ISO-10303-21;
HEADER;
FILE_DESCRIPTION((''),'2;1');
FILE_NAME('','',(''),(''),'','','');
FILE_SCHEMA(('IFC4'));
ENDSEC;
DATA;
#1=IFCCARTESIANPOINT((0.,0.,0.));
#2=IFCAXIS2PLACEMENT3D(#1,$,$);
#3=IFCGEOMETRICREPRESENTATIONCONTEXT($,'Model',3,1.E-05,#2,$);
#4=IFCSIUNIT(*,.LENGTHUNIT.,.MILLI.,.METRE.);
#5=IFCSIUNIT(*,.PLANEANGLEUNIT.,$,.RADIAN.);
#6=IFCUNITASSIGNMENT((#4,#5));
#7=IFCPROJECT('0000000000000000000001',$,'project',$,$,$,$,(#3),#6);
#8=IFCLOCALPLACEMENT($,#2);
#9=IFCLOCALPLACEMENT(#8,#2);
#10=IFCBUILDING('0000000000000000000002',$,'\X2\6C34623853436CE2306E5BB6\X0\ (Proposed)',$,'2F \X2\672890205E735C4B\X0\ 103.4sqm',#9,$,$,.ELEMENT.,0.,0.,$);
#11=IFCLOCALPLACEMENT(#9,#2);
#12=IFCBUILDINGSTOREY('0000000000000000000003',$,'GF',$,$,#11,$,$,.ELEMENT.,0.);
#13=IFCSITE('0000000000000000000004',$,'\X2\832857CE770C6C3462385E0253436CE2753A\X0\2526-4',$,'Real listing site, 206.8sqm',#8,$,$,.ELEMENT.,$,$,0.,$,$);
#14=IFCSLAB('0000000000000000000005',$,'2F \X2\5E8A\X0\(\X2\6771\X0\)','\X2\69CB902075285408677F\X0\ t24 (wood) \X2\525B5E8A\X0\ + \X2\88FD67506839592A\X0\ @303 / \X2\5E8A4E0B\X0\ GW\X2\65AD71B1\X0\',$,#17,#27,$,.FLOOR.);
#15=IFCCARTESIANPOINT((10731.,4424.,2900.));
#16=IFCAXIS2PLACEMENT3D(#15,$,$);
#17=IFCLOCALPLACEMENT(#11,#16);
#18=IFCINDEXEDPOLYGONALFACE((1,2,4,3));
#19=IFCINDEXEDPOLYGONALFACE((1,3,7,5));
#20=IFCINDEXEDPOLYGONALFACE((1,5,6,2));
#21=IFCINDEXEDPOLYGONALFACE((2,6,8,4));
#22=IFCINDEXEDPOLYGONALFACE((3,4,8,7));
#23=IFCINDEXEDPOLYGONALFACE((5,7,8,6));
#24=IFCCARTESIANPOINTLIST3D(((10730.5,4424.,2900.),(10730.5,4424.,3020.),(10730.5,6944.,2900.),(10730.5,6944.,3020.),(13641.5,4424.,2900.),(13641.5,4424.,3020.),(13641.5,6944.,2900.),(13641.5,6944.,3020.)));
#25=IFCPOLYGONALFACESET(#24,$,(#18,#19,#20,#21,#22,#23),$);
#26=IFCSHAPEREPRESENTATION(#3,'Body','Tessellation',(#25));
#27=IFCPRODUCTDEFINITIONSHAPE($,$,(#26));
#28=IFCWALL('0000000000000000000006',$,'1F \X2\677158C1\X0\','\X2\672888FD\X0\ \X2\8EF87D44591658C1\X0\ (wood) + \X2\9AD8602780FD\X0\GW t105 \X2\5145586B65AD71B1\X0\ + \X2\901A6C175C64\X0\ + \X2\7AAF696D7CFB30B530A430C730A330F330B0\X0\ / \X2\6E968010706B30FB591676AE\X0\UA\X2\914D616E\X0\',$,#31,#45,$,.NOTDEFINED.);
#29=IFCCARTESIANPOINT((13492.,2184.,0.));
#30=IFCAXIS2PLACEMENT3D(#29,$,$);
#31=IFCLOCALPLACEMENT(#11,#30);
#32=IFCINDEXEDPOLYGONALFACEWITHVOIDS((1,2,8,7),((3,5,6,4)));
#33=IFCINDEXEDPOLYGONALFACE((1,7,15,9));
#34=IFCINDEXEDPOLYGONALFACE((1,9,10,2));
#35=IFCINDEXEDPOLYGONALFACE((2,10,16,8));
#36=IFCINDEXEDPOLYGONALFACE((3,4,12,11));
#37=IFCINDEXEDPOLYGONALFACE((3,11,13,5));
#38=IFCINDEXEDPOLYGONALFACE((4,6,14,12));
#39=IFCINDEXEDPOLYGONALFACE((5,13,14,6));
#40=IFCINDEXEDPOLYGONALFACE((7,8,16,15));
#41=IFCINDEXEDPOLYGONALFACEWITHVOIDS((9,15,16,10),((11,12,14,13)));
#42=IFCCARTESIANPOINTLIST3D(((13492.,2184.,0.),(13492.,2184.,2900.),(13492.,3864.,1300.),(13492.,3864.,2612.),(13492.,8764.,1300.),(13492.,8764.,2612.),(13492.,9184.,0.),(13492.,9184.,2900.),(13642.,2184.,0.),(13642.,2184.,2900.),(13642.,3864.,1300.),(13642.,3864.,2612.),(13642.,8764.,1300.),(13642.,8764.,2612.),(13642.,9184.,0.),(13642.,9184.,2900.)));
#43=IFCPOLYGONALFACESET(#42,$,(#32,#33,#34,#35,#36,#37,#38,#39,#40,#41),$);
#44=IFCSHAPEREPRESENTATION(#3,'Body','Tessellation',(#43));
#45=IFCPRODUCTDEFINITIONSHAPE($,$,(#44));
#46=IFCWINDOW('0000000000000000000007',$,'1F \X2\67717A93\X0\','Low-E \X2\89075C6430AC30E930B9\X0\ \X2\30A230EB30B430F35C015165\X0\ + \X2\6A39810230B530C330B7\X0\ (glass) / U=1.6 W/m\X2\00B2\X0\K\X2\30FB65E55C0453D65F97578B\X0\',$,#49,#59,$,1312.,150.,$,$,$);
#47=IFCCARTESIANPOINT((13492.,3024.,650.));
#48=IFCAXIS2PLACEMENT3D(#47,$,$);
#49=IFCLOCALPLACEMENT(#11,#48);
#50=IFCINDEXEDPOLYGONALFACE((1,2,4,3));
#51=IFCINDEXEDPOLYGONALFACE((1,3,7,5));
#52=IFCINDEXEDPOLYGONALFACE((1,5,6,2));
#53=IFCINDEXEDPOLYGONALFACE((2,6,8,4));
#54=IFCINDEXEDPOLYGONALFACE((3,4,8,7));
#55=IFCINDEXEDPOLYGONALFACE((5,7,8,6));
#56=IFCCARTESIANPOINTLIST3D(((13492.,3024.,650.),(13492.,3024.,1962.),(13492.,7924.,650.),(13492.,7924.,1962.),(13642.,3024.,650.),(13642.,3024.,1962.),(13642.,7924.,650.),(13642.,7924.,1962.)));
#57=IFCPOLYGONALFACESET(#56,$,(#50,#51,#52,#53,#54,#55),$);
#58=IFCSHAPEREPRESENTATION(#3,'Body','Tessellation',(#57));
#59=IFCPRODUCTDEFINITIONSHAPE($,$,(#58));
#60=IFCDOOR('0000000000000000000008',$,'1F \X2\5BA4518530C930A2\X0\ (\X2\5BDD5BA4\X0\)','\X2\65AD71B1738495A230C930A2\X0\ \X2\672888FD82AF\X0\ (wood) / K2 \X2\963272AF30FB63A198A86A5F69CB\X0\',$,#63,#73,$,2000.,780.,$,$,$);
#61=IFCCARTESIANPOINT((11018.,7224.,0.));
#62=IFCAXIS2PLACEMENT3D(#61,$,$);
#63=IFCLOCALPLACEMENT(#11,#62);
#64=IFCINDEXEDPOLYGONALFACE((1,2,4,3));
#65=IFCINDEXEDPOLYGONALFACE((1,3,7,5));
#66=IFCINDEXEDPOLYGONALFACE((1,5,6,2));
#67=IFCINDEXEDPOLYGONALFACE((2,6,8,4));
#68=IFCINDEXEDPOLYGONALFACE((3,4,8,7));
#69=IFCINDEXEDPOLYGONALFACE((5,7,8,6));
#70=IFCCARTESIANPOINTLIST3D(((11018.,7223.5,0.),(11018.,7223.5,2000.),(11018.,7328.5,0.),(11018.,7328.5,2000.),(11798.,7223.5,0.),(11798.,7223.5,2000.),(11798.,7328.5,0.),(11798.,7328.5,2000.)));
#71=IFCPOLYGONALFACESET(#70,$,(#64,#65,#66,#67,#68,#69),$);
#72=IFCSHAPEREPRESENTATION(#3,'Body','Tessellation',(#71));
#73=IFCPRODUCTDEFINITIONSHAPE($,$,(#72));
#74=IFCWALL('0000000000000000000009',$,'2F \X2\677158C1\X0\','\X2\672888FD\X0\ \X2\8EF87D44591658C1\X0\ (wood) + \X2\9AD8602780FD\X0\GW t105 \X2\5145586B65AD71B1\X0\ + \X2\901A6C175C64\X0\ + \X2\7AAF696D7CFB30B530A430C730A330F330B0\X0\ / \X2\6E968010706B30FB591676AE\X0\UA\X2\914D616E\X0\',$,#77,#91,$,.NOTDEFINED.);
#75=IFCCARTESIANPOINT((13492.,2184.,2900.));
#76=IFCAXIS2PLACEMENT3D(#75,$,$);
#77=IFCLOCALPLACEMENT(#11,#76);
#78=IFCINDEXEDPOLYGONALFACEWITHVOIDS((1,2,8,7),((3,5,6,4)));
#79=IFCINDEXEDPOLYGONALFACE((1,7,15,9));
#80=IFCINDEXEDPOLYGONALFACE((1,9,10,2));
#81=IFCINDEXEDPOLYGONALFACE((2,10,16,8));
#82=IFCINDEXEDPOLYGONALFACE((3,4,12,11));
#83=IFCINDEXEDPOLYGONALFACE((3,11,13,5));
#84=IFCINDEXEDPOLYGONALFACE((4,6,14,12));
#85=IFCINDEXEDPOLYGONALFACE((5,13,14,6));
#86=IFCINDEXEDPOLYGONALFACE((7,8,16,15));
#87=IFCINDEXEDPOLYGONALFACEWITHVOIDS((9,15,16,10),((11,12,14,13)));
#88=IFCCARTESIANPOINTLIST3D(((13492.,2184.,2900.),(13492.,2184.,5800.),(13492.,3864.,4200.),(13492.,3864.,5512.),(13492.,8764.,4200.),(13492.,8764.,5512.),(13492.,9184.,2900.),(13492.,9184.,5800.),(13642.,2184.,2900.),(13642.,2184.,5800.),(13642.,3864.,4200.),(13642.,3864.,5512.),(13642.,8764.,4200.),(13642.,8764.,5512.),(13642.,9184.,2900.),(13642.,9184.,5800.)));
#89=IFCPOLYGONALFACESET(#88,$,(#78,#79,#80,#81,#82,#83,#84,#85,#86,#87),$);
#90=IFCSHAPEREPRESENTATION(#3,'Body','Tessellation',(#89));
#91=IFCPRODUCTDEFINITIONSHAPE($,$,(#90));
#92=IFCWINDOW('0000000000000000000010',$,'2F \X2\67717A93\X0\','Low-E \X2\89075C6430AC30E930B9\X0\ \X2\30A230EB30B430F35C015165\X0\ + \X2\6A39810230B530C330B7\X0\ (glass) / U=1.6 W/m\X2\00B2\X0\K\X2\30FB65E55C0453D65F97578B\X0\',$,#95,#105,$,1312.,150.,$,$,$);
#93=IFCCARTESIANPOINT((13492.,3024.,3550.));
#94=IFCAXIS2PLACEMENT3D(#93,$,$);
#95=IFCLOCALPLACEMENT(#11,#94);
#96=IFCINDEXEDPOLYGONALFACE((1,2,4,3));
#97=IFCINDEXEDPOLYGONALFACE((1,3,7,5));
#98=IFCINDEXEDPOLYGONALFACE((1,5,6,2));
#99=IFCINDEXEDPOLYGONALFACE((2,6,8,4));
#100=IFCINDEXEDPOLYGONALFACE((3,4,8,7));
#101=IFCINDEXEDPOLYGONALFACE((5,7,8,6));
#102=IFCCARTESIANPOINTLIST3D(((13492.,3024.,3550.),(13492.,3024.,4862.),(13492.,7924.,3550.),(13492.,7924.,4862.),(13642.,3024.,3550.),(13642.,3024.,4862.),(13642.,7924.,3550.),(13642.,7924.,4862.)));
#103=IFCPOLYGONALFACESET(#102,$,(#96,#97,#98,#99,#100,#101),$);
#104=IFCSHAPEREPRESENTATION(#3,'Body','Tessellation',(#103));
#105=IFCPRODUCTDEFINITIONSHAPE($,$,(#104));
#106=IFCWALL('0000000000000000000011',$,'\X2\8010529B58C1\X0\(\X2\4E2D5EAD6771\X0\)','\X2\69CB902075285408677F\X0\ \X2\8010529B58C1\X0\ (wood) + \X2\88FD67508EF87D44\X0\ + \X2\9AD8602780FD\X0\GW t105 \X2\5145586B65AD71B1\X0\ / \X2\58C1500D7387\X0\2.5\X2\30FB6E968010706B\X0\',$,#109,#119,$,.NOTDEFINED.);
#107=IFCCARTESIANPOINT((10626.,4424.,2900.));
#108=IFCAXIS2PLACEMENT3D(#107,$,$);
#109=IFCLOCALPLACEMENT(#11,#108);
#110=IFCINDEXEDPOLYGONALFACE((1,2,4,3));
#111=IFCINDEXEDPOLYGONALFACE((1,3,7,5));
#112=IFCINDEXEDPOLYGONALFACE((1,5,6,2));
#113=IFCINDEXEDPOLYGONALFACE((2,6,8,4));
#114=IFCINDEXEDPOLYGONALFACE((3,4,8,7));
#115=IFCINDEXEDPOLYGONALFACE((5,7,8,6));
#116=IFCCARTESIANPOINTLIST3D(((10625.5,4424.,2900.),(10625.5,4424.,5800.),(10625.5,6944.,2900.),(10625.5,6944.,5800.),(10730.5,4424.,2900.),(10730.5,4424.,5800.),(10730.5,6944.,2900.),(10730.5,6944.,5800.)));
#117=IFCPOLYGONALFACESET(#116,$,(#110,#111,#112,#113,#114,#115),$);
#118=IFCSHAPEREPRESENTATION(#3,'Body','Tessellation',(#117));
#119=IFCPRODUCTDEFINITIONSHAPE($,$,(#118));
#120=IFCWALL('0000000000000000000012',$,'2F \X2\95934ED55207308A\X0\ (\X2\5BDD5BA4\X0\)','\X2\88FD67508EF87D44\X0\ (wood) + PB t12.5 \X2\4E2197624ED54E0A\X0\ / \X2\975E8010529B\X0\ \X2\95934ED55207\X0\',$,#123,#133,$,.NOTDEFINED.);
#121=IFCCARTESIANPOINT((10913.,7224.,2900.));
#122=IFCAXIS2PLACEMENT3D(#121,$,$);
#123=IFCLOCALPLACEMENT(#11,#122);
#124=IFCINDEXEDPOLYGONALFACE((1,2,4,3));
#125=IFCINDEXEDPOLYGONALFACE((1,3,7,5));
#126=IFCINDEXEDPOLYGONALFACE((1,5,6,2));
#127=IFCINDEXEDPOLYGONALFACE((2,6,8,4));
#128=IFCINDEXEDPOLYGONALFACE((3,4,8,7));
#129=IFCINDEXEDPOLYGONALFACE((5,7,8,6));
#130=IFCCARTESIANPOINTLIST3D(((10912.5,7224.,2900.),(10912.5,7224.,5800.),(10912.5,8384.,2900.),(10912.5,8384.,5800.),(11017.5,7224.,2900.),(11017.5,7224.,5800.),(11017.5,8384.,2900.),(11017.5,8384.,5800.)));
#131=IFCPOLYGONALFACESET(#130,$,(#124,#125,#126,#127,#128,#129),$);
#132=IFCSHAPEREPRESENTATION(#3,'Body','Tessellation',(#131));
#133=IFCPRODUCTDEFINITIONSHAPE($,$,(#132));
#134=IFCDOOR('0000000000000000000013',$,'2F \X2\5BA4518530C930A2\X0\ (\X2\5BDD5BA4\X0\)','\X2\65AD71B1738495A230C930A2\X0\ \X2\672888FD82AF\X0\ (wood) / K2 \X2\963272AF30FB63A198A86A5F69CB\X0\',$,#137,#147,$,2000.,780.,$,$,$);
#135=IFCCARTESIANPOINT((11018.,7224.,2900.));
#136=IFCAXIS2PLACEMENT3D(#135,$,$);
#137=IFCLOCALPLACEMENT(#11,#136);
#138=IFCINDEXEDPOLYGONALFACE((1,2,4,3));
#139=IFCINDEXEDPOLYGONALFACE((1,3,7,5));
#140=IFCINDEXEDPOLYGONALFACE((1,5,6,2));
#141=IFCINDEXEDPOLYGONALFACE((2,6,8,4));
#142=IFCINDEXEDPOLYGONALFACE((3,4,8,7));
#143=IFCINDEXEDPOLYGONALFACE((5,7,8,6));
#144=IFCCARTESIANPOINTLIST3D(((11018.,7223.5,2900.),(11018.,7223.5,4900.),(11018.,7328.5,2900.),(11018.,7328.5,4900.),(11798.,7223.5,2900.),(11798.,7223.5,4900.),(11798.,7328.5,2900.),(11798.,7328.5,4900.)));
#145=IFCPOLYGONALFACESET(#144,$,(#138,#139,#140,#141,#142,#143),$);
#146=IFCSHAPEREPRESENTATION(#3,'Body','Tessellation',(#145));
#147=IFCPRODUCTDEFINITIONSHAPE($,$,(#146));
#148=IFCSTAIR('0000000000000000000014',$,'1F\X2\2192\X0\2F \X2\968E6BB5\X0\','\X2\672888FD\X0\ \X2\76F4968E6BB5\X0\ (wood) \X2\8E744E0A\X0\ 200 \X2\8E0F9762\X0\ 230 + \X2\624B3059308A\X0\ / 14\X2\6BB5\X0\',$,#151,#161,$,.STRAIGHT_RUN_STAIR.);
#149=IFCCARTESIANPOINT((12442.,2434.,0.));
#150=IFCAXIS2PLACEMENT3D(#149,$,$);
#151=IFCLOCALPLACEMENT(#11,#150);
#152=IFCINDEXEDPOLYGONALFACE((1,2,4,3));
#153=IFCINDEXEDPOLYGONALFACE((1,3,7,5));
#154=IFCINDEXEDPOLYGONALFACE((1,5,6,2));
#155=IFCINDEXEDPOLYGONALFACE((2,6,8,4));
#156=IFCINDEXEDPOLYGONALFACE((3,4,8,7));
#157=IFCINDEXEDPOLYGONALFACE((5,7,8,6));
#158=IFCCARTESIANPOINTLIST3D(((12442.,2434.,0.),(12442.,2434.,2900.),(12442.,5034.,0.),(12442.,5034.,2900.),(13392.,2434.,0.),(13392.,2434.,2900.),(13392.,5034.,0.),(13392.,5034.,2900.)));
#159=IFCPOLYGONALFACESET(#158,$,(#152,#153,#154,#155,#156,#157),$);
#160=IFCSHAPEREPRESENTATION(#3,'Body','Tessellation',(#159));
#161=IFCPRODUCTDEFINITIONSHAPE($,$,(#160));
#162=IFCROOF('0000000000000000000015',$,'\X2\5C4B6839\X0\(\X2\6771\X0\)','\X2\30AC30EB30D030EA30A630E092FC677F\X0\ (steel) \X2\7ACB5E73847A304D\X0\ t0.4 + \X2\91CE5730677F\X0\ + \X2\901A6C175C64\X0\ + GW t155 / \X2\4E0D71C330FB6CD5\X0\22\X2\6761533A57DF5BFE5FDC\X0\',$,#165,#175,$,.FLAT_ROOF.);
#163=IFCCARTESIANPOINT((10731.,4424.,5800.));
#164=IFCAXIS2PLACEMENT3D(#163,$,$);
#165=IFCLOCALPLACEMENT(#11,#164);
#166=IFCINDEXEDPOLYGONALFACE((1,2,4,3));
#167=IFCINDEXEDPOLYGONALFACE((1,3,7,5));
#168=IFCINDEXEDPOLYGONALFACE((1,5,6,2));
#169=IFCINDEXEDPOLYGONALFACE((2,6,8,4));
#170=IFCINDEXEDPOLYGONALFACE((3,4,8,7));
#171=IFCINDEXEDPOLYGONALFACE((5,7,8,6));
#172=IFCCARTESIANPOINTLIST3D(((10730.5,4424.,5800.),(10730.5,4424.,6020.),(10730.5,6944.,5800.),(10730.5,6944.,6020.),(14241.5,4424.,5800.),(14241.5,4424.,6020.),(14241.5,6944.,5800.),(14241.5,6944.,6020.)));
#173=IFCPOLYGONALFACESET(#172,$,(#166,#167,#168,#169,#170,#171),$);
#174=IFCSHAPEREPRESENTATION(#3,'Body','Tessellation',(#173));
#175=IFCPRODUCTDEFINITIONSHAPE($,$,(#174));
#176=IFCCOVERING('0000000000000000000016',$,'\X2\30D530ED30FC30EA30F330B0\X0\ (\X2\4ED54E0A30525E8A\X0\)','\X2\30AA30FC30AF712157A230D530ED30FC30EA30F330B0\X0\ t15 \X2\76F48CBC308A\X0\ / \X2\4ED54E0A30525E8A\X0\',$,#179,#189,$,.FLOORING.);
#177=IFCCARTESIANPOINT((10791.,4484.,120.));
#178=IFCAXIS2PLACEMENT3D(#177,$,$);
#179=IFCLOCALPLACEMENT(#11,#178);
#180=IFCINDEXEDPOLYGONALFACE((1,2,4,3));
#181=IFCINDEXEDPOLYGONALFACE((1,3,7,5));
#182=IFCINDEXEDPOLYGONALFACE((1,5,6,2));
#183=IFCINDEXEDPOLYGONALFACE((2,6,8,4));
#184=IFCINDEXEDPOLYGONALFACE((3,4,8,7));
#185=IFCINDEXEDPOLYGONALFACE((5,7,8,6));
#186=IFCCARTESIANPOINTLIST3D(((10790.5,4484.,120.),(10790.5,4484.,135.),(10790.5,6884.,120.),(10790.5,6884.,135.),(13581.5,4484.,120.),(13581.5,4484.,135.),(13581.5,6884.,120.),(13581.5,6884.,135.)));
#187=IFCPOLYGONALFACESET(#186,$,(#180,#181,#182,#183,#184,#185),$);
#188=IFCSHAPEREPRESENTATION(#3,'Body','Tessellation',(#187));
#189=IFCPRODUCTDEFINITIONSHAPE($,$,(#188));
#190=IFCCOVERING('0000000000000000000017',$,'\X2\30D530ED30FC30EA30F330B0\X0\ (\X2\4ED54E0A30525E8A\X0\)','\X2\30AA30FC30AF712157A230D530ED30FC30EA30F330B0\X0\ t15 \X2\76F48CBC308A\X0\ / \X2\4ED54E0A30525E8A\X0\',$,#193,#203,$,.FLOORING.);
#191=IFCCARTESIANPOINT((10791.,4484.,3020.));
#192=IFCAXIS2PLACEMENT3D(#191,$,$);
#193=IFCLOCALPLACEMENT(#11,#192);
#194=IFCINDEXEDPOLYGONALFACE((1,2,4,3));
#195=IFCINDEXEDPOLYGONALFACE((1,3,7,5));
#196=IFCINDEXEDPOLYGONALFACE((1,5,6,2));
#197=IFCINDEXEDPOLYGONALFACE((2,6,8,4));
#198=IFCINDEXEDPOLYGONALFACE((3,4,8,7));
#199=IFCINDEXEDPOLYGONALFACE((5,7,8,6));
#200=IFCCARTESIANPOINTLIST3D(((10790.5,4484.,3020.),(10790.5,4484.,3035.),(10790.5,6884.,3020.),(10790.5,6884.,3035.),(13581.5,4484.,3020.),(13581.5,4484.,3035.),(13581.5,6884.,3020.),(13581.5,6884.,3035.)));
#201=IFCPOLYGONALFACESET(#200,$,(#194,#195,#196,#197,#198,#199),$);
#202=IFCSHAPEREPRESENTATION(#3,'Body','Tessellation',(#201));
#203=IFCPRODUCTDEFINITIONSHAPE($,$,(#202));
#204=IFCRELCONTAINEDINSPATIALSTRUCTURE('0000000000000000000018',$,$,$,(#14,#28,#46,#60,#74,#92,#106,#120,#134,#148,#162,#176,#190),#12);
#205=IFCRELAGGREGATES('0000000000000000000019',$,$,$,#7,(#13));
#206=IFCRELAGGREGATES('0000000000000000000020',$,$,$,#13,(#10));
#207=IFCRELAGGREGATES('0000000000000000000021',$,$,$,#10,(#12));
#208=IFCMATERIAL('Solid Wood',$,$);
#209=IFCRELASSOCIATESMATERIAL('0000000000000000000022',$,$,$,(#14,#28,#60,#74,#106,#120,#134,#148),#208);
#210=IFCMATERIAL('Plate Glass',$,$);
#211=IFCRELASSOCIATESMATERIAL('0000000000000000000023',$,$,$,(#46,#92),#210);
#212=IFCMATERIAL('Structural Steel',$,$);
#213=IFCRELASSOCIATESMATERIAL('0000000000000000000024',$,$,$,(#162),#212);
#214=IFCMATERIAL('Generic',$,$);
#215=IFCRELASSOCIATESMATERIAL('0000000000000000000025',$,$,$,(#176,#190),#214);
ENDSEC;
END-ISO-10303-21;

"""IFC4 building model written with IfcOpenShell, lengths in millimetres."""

from ifc_helpers import new_model, si_unit, frame, frame_2d, origin, place, context, project, spatial, rectangle, extrude, material, element, fill, save


model = new_model("IFC4")

# Units and contexts
model_context = context("Model", 3, precision=1e-05, world=origin())
ifc_project = project(units=[si_unit("LENGTHUNIT", "METRE", prefix="MILLI"), si_unit("PLANEANGLEUNIT", "RADIAN")], contexts=[model_context])

# Site, building, storey
site_placement = place(None, origin())
site = spatial("IfcSite", under=ifc_project, at=site_placement, Name="茨城県水戸市千波町2526-4", ObjectType="Real listing site, 206.8sqm", CompositionType="ELEMENT", RefElevation=0.0)
building_placement = place(site_placement, origin())
building = spatial("IfcBuilding", under=site, at=building_placement, Name="水戸千波の家 (Proposed)", ObjectType="2F 木造平屋 103.4sqm", CompositionType="ELEMENT", ElevationOfRefHeight=0.0, ElevationOfTerrain=0.0)
storey_placement = place(building_placement, origin())
storey = spatial("IfcBuildingStorey", under=building, at=storey_placement, Name="GF", CompositionType="ELEMENT", Elevation=0.0)

# Slab
ifc_material_1 = material(Name="Solid Wood")
slab_1_placement = place(storey_placement, frame((10731.0, 4424.0, 2900.0)))
element("IfcSlab", 1, at=slab_1_placement, inside=storey, material=ifc_material_1, Name="2F 床(東)", Description="構造用合板 t24 (wood) 剛床 + 製材根太 @303 / 床下 GW断熱", PredefinedType="FLOOR", context=model_context, shape_type="SweptSolid", body=[
    extrude(rectangle(XDim=2911.0, YDim=2520.0, at=frame_2d((1455.0, 1260.0))), frame((10731.0, 4424.0, 2900.0)), (0.0, 0.0, 1.0), 120.0),
])

# Wall, opening, window
wall_1_placement = place(storey_placement, frame((13492.0, 2184.0, 0.0)))
wall_1 = element("IfcWall", 2, at=wall_1_placement, inside=storey, material=ifc_material_1, Name="1F 東壁", Description="木製 軸組外壁 (wood) + 高性能GW t105 充填断熱 + 通気層 + 窯業系サイディング / 準耐火・外皮UA配慮", PredefinedType="NOTDEFINED", context=model_context, shape_type="SweptSolid", body=[
    extrude(rectangle(XDim=150.0, YDim=7000.0, at=frame_2d((75.0, 3500.0))), frame((13492.0, 2184.0, 0.0)), (0.0, 0.0, 1.0), 2900.0),
])
opening_1_placement = place(storey_placement, frame((13492.0, 3024.0, 650.0)))
opening_1 = element("IfcOpeningElement", 3, at=opening_1_placement, cuts=wall_1, PredefinedType="NOTDEFINED", context=model_context, shape_type="SweptSolid", body=[
    extrude(rectangle(XDim=150.0, YDim=4900.0, at=frame_2d((75.0, 2450.0))), frame((13492.0, 3024.0, 650.0)), (0.0, 0.0, 1.0), 1312.0),
])
ifc_material_2 = material(Name="Plate Glass")
window_1_placement = place(storey_placement, frame((13492.0, 3024.0, 650.0)))
window_1 = element("IfcWindow", 4, at=window_1_placement, inside=storey, material=ifc_material_2, Name="1F 東窓", Description="Low-E 複層ガラス アルゴン封入 + 樹脂サッシ (glass) / U=1.6 W/m²K・日射取得型", OverallHeight=1312.0, OverallWidth=150.0, context=model_context, shape_type="SweptSolid", body=[
    extrude(rectangle(XDim=150.0, YDim=4900.0, at=frame_2d((75.0, 2450.0))), frame((13492.0, 3024.0, 650.0)), (0.0, 0.0, 1.0), 1312.0),
])
fill(opening_1, window_1)

# Door
door_1_placement = place(storey_placement, frame((11018.0, 7224.0, 0.0)))
element("IfcDoor", 5, at=door_1_placement, inside=storey, material=ifc_material_1, Name="1F 室内ドア (寝室)", Description="断熱玄関ドア 木製芯 (wood) / K2 防犯・採風機構", OverallHeight=2000.0, OverallWidth=780.0, context=model_context, shape_type="SweptSolid", body=[
    extrude(rectangle(XDim=780.0, YDim=105.0, at=frame_2d((390.0, 52.0))), frame((11018.0, 7224.0, 0.0)), (0.0, 0.0, 1.0), 2000.0),
])

# Wall, opening, window
wall_2_placement = place(storey_placement, frame((13492.0, 2184.0, 2900.0)))
wall_2 = element("IfcWall", 6, at=wall_2_placement, inside=storey, material=ifc_material_1, Name="2F 東壁", Description="木製 軸組外壁 (wood) + 高性能GW t105 充填断熱 + 通気層 + 窯業系サイディング / 準耐火・外皮UA配慮", PredefinedType="NOTDEFINED", context=model_context, shape_type="SweptSolid", body=[
    extrude(rectangle(XDim=150.0, YDim=7000.0, at=frame_2d((75.0, 3500.0))), frame((13492.0, 2184.0, 2900.0)), (0.0, 0.0, 1.0), 2900.0),
])
opening_2_placement = place(storey_placement, frame((13492.0, 3024.0, 3550.0)))
opening_2 = element("IfcOpeningElement", 7, at=opening_2_placement, cuts=wall_2, PredefinedType="NOTDEFINED", context=model_context, shape_type="SweptSolid", body=[
    extrude(rectangle(XDim=150.0, YDim=4900.0, at=frame_2d((75.0, 2450.0))), frame((13492.0, 3024.0, 3550.0)), (0.0, 0.0, 1.0), 1312.0),
])
window_2_placement = place(storey_placement, frame((13492.0, 3024.0, 3550.0)))
window_2 = element("IfcWindow", 8, at=window_2_placement, inside=storey, material=ifc_material_2, Name="2F 東窓", Description="Low-E 複層ガラス アルゴン封入 + 樹脂サッシ (glass) / U=1.6 W/m²K・日射取得型", OverallHeight=1312.0, OverallWidth=150.0, context=model_context, shape_type="SweptSolid", body=[
    extrude(rectangle(XDim=150.0, YDim=4900.0, at=frame_2d((75.0, 2450.0))), frame((13492.0, 3024.0, 3550.0)), (0.0, 0.0, 1.0), 1312.0),
])
fill(opening_2, window_2)

# Walls
wall_3_placement = place(storey_placement, frame((10626.0, 4424.0, 2900.0)))
element("IfcWall", 9, at=wall_3_placement, inside=storey, material=ifc_material_1, Name="耐力壁(中庭東)", Description="構造用合板 耐力壁 (wood) + 製材軸組 + 高性能GW t105 充填断熱 / 壁倍率2.5・準耐火", PredefinedType="NOTDEFINED", context=model_context, shape_type="SweptSolid", body=[
    extrude(rectangle(XDim=105.0, YDim=2520.0, at=frame_2d((52.0, 1260.0))), frame((10626.0, 4424.0, 2900.0)), (0.0, 0.0, 1.0), 2900.0),
])
wall_4_placement = place(storey_placement, frame((10913.0, 7224.0, 2900.0)))
element("IfcWall", 10, at=wall_4_placement, inside=storey, material=ifc_material_1, Name="2F 間仕切り (寝室)", Description="製材軸組 (wood) + PB t12.5 両面仕上 / 非耐力 間仕切", PredefinedType="NOTDEFINED", context=model_context, shape_type="SweptSolid", body=[
    extrude(rectangle(XDim=105.0, YDim=1160.0, at=frame_2d((52.0, 580.0))), frame((10913.0, 7224.0, 2900.0)), (0.0, 0.0, 1.0), 2900.0),
])

# Door
door_2_placement = place(storey_placement, frame((11018.0, 7224.0, 2900.0)))
element("IfcDoor", 11, at=door_2_placement, inside=storey, material=ifc_material_1, Name="2F 室内ドア (寝室)", Description="断熱玄関ドア 木製芯 (wood) / K2 防犯・採風機構", OverallHeight=2000.0, OverallWidth=780.0, context=model_context, shape_type="SweptSolid", body=[
    extrude(rectangle(XDim=780.0, YDim=105.0, at=frame_2d((390.0, 52.0))), frame((11018.0, 7224.0, 2900.0)), (0.0, 0.0, 1.0), 2000.0),
])

# Stair
stair_placement = place(storey_placement, frame((12442.0, 2434.0, 0.0)))
element("IfcStair", 12, at=stair_placement, inside=storey, material=ifc_material_1, Name="1F→2F 階段", Description="木製 直階段 (wood) 蹴上 200 踏面 230 + 手すり / 14段", PredefinedType="STRAIGHT_RUN_STAIR", context=model_context, shape_type="SweptSolid", body=[
    extrude(rectangle(XDim=950.0, YDim=2600.0, at=frame_2d((475.0, 1300.0))), frame((12442.0, 2434.0, 0.0)), (0.0, 0.0, 1.0), 2900.0),
])

# Roof
ifc_material_3 = material(Name="Structural Steel")
for number, where, name in (
    (13, (10731.0, 4424.0, 5800.0), "屋根(東)"),
):
    element("IfcRoof", number, at=place(storey_placement, frame(where)), inside=storey, material=ifc_material_3, Name=name, Description="ガルバリウム鋼板 (steel) 立平葺き t0.4 + 野地板 + 通気層 + GW t155 / 不燃・法22条区域対応", PredefinedType="FLAT_ROOF", context=model_context, shape_type="SweptSolid", body=[
        extrude(rectangle(XDim=3511.0, YDim=2520.0, at=frame_2d((1755.0, 1260.0))), frame((10731.0, 4424.0, 5800.0)), (0.0, 0.0, 1.0), 220.0),
    ])

# Coverings
ifc_material_4 = material(Name="Generic")
covering_1_placement = place(storey_placement, frame((10791.0, 4484.0, 120.0)))
element("IfcCovering", 14, at=covering_1_placement, inside=storey, material=ifc_material_4, Name="フローリング (仕上げ床)", Description="オーク無垢フローリング t15 直貼り / 仕上げ床", PredefinedType="FLOORING", context=model_context, shape_type="SweptSolid", body=[
    extrude(rectangle(XDim=2791.0, YDim=2400.0, at=frame_2d((1395.0, 1200.0))), frame((10791.0, 4484.0, 120.0)), (0.0, 0.0, 1.0), 15.0),
])
covering_2_placement = place(storey_placement, frame((10791.0, 4484.0, 3020.0)))
element("IfcCovering", 15, at=covering_2_placement, inside=storey, material=ifc_material_4, Name="フローリング (仕上げ床)", Description="オーク無垢フローリング t15 直貼り / 仕上げ床", PredefinedType="FLOORING", context=model_context, shape_type="SweptSolid", body=[
    extrude(rectangle(XDim=2791.0, YDim=2400.0, at=frame_2d((1395.0, 1200.0))), frame((10791.0, 4484.0, 3020.0)), (0.0, 0.0, 1.0), 15.0),
])

save(model, "model.ifc")
